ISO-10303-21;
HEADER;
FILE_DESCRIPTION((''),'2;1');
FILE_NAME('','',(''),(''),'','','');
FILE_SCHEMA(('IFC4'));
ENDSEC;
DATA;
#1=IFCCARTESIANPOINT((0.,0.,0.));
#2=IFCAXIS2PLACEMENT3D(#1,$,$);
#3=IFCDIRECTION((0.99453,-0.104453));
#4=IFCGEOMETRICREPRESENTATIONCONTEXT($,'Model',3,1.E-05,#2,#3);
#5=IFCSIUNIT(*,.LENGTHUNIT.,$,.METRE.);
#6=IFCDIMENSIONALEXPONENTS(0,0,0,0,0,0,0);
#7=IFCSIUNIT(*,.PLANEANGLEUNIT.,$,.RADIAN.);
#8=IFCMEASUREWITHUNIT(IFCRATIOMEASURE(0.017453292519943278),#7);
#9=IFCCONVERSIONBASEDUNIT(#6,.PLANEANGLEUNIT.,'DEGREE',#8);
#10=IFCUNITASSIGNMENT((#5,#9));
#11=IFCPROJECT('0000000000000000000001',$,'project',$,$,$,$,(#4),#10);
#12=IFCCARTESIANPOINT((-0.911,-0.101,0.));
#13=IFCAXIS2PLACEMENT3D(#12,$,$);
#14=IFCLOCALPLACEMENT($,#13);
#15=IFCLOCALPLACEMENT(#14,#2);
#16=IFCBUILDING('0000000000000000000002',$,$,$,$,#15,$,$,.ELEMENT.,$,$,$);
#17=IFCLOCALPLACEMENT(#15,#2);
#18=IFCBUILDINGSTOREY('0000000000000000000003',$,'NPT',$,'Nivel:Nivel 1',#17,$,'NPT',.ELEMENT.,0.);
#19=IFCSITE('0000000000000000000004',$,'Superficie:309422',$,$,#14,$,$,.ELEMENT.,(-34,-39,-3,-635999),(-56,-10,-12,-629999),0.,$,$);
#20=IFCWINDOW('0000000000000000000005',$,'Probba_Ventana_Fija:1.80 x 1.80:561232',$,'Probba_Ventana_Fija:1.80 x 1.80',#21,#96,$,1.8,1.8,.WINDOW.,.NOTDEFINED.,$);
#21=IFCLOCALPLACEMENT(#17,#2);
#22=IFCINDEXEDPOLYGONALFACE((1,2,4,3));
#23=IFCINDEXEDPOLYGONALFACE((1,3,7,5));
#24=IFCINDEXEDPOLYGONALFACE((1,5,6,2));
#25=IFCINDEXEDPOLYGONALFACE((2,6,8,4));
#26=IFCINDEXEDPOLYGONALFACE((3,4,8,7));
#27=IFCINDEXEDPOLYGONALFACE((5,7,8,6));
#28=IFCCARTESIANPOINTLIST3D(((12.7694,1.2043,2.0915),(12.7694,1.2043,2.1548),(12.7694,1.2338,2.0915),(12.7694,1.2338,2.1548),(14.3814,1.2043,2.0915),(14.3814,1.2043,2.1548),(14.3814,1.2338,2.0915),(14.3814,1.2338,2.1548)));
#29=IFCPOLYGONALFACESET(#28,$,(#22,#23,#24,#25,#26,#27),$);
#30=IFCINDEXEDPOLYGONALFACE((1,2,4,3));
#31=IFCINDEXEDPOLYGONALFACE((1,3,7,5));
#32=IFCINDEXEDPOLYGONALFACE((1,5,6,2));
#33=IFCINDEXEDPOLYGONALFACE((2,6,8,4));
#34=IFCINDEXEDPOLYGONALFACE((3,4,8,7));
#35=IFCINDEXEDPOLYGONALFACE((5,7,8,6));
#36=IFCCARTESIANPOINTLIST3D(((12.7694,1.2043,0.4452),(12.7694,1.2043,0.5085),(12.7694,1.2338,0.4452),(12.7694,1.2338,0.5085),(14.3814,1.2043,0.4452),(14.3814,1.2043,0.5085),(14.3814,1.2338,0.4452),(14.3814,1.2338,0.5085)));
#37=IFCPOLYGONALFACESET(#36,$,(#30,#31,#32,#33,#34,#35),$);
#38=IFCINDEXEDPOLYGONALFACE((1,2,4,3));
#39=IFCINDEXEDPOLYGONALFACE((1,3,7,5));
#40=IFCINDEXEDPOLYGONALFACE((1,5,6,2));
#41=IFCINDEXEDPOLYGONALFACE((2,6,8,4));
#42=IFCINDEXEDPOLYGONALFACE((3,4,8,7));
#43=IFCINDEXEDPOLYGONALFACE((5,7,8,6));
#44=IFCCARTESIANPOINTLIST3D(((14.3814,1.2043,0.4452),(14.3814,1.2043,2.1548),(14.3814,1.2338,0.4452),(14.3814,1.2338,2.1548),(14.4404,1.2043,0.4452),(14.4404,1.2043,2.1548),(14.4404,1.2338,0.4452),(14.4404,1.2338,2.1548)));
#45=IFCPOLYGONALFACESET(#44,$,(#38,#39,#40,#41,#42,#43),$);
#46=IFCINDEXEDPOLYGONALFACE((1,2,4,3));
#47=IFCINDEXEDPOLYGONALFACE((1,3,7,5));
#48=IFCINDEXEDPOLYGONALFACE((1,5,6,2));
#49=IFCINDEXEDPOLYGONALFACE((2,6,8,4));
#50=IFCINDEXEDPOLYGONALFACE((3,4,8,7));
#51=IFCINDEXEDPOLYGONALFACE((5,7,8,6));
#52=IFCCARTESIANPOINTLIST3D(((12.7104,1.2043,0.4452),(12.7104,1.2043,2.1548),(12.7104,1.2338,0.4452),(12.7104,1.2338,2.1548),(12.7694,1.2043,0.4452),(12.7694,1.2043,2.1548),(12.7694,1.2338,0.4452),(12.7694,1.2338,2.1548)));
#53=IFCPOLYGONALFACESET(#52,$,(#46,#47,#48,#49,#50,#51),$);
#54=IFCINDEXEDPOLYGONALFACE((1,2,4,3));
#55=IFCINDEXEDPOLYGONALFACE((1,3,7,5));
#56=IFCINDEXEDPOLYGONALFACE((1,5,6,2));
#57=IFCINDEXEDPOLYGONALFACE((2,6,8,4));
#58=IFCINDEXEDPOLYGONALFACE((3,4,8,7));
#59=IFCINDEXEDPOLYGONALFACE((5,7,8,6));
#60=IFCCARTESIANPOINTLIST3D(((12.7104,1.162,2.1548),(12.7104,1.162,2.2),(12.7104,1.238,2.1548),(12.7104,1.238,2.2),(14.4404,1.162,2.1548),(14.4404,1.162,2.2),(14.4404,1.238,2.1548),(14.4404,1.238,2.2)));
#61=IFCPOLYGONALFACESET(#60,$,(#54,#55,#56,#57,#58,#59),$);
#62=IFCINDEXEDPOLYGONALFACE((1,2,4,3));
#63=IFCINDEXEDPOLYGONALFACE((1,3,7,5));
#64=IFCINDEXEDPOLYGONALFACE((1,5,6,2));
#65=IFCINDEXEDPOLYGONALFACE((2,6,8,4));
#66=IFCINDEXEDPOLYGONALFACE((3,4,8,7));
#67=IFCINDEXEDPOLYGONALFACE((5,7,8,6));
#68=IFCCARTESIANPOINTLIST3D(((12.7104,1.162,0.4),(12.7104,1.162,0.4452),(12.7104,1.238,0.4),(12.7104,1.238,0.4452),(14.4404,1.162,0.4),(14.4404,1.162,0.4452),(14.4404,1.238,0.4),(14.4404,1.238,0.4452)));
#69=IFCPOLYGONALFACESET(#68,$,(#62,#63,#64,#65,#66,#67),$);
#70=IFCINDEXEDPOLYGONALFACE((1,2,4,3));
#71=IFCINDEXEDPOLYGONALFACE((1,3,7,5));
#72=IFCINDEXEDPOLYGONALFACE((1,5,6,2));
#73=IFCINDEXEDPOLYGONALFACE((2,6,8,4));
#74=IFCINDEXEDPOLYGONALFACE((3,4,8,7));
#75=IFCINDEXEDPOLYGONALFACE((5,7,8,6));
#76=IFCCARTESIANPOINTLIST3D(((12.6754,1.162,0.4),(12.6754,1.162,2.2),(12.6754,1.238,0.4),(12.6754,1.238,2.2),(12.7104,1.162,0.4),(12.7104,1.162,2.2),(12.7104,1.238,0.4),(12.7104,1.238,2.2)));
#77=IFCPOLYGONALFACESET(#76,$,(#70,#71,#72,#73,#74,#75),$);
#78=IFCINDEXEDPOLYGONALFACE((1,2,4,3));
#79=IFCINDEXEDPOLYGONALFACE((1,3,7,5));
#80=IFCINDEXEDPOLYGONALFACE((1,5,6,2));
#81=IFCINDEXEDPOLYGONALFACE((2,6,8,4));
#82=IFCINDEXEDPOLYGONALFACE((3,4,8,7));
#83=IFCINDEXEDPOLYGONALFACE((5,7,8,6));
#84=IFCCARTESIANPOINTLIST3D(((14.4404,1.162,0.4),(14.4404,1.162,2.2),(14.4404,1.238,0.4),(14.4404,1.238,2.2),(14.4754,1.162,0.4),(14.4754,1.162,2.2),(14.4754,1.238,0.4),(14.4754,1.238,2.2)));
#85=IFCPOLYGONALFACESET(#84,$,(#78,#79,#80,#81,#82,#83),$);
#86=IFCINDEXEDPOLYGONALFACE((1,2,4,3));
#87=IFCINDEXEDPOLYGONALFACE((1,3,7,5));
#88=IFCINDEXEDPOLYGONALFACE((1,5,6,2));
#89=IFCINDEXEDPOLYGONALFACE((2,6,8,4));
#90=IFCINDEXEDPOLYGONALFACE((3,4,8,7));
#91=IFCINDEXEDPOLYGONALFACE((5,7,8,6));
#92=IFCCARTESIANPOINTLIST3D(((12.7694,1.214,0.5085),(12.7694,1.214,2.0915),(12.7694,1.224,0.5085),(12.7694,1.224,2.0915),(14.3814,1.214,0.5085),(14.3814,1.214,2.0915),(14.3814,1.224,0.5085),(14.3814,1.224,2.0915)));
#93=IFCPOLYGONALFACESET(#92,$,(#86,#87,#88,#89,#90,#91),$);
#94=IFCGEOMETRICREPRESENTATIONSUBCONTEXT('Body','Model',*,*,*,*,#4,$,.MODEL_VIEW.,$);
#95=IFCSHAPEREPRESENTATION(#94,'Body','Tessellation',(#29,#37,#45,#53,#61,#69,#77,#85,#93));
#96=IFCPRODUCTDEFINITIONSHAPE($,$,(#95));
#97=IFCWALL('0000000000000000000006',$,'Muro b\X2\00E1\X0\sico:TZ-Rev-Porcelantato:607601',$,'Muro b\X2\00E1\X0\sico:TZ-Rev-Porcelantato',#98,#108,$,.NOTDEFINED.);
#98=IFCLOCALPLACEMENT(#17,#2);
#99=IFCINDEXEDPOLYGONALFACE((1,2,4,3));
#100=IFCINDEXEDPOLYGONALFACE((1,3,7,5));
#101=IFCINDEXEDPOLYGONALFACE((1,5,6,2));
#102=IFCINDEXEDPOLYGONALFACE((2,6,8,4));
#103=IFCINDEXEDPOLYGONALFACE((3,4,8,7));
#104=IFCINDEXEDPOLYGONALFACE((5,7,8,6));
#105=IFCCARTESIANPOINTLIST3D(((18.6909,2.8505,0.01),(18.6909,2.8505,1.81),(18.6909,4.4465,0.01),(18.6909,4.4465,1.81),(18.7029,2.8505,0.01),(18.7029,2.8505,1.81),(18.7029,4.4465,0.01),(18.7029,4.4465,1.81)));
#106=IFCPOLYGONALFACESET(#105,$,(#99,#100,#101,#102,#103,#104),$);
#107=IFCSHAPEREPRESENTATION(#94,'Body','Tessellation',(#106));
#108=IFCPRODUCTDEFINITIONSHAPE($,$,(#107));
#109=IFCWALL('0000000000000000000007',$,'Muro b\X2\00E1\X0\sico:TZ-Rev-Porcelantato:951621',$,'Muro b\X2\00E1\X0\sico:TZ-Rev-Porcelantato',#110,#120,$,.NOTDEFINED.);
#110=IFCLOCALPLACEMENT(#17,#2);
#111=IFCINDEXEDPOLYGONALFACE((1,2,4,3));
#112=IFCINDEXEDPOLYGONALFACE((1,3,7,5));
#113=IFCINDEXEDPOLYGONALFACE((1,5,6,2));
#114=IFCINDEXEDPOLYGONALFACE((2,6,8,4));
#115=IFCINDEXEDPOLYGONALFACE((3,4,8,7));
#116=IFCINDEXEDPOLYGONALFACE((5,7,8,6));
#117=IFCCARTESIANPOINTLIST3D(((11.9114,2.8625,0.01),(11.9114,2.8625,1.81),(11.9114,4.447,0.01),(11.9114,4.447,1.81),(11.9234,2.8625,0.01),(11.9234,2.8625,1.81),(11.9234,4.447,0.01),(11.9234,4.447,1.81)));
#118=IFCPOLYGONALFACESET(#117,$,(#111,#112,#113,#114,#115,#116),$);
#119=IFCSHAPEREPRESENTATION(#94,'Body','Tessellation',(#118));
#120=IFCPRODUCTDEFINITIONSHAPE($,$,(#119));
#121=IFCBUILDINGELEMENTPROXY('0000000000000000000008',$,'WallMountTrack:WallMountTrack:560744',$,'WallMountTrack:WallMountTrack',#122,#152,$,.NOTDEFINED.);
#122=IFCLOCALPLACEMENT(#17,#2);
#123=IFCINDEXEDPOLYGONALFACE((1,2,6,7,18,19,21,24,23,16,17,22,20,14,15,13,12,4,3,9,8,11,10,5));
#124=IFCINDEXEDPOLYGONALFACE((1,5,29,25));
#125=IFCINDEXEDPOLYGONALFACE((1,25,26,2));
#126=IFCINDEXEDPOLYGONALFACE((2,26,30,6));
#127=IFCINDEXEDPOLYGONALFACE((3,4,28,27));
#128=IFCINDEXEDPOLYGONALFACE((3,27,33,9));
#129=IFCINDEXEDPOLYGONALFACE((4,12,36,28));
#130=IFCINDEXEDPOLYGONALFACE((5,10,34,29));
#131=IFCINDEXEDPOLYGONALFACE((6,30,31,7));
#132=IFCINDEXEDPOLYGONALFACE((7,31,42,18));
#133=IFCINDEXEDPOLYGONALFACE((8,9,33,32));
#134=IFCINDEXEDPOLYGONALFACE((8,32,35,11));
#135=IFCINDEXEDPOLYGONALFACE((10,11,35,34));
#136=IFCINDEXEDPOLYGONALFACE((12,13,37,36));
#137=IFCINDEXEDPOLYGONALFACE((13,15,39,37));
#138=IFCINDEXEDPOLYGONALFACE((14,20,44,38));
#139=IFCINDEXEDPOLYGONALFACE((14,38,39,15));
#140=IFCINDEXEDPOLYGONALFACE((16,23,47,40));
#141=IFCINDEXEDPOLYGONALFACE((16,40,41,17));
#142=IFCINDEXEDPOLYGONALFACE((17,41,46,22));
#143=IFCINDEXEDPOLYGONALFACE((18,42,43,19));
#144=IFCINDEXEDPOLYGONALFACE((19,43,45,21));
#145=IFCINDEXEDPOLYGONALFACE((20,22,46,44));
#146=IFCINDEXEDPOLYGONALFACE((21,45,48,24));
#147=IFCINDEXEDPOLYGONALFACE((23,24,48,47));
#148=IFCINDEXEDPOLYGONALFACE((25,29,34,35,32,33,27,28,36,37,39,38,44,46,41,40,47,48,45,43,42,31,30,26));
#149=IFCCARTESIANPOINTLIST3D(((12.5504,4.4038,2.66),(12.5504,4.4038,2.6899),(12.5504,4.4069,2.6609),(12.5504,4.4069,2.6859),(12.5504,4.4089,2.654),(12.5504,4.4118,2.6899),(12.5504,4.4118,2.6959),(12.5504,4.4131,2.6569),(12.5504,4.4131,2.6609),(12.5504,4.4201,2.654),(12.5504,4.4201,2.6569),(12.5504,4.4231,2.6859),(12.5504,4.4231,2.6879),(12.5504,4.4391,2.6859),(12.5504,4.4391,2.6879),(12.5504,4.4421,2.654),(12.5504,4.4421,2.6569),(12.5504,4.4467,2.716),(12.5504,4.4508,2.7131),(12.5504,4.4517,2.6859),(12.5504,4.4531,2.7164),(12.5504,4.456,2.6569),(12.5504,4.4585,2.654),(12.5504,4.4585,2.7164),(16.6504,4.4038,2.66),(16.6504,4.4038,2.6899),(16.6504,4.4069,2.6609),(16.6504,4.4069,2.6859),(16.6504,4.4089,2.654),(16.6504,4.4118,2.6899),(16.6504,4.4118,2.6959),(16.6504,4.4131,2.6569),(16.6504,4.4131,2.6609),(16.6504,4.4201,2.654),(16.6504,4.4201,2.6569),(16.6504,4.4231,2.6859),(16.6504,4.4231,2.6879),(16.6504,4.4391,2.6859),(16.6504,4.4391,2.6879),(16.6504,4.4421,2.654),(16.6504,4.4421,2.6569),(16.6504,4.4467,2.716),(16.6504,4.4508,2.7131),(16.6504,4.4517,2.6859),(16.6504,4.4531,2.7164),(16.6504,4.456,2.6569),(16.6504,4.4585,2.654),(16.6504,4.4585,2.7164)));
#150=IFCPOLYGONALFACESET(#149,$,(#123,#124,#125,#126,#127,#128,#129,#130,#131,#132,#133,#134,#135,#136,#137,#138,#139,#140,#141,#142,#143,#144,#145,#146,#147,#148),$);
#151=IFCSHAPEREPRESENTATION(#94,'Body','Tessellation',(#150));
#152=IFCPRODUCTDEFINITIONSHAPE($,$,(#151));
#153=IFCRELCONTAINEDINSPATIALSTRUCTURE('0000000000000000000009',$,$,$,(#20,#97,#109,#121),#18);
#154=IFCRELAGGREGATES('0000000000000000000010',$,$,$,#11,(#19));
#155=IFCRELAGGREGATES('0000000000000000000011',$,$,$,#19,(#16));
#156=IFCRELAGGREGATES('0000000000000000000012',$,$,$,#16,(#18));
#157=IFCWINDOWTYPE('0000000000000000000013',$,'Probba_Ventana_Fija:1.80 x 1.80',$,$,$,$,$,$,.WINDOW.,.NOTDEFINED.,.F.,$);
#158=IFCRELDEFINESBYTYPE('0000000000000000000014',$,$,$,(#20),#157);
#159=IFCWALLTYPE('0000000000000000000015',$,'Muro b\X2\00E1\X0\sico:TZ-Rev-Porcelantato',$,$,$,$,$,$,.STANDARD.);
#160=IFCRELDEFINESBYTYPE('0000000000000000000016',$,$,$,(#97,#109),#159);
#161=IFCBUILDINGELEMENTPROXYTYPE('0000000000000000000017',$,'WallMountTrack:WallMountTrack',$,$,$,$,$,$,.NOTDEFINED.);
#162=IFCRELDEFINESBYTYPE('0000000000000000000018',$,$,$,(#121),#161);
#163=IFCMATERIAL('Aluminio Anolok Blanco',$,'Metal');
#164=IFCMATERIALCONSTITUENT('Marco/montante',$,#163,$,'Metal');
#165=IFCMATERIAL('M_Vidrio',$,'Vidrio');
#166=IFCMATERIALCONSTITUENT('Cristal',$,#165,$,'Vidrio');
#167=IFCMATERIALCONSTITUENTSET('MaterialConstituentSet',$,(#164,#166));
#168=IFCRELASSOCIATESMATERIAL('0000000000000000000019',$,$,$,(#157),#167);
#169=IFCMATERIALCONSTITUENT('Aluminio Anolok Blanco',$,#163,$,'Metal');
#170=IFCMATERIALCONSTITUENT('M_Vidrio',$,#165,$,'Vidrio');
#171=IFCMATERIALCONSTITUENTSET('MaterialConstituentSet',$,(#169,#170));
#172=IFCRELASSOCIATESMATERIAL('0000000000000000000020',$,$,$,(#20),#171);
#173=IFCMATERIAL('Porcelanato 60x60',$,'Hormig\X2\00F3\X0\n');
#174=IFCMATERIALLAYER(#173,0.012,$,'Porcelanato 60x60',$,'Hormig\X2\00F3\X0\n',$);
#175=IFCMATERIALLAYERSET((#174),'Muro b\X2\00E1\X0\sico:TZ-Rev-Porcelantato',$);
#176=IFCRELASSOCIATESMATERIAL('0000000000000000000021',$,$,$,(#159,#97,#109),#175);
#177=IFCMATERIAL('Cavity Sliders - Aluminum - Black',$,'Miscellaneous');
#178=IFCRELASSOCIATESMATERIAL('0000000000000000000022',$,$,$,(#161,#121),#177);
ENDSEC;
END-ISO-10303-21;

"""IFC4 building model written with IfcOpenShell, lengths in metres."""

from ifc_helpers import new_model, entity, si_unit, converted_unit, direction, frame, frame_2d, origin, origin_2d_with_axis, place, context, subcontext, project, spatial, polyline, rectangle, outline, extrude, source, transform, mapped, material, layer, layer_set, layer_usage, constituent, constituent_set, type_object, type_shapes, element, save


model = new_model("IFC4")

# Units and contexts
model_context = context("Model", 3, precision=1e-05, world=origin(), true_north=direction((0.99453, -0.104453)))
body_context = subcontext(model_context, "Body", "Model", "MODEL_VIEW")
ifc_project = project(units=[si_unit("LENGTHUNIT", "METRE"), converted_unit("PLANEANGLEUNIT", "DEGREE", entity("IfcRatioMeasure", 0.017453292519943278), si_unit("PLANEANGLEUNIT", "RADIAN"), dimensions=[0, 0, 0, 0, 0, 0, 0])], contexts=[model_context])

# Site, building, storey
site_placement = place(None, frame((-0.911, -0.101, 0.0)))
site = spatial("IfcSite", under=ifc_project, at=site_placement, Name="Superficie:309422", CompositionType="ELEMENT", RefLatitude=(-34, -39, -3, -635999), RefLongitude=(-56, -10, -12, -629999), RefElevation=0.0)
building_placement = place(site_placement, origin())
building = spatial("IfcBuilding", under=site, at=building_placement, CompositionType="ELEMENT")
storey_placement = place(building_placement, origin())
storey = spatial("IfcBuildingStorey", under=building, at=storey_placement, Name="NPT", ObjectType="Nivel:Nivel 1", LongName="NPT", CompositionType="ELEMENT", Elevation=0.0)

# Window
ifc_material_1 = material(Name="Aluminio Anolok Blanco", Category="Metal")
ifc_constituent_1 = constituent(ifc_material_1, Name="Aluminio Anolok Blanco", Category="Metal")
ifc_material_2 = material(Name="M_Vidrio", Category="Vidrio")
ifc_constituent_2 = constituent(ifc_material_2, Name="M_Vidrio", Category="Vidrio")
ifc_constituent_set_1 = constituent_set(constituents=[ifc_constituent_1, ifc_constituent_2], Name="MaterialConstituentSet")
ifc_constituent_3 = constituent(ifc_material_1, Name="Marco/montante", Category="Metal")
ifc_constituent_4 = constituent(ifc_material_2, Name="Cristal", Category="Vidrio")
ifc_constituent_set_2 = constituent_set(constituents=[ifc_constituent_3, ifc_constituent_4], Name="MaterialConstituentSet")
window_type = type_object("IfcWindowType", Name="Probba_Ventana_Fija:1.80 x 1.80", ParameterTakesPrecedence=False, PartitioningType="NOTDEFINED", PredefinedType="WINDOW", material=ifc_constituent_set_2)
shared_shape_1 = source(origin(), body_context, "Body", "SweptSolid", [
    extrude(rectangle(XDim=0.0295, YDim=1.612, at=origin_2d_with_axis()), frame((0.9, 0.019, 1.6915), z_axis=(0.0, 0.0, 1.0), x_axis=(0.0, 1.0, 0.0)), (0.0, 0.0, 1.0), 0.0633),
    extrude(rectangle(XDim=0.0295, YDim=1.612, at=frame_2d((0.0, 0.0), x_axis=(1.0, 0.0))), frame((0.9, 0.019, 0.0452), z_axis=(0.0, 0.0, 1.0), x_axis=(0.0, 1.0, 0.0)), (0.0, 0.0, 1.0), 0.0633),
    extrude(rectangle(XDim=0.059, YDim=0.0295, at=origin_2d_with_axis()), frame((0.0645, 0.019, 0.0452)), (0.0, 0.0, 1.0), 1.7096),
    extrude(rectangle(XDim=0.059, YDim=0.0295, at=origin_2d_with_axis()), frame((1.7355, 0.019, 0.0452)), (0.0, 0.0, 1.0), 1.7096),
    extrude(rectangle(XDim=0.076, YDim=1.73, at=frame_2d((0.0, 0.0), x_axis=(1.0, 0.0))), frame((0.9, 0.038, 1.7548), z_axis=(0.0, 0.0, 1.0), x_axis=(0.0, 1.0, 0.0)), (0.0, 0.0, 1.0), 0.0452),
    extrude(rectangle(XDim=0.076, YDim=1.73, at=frame_2d((0.0, 0.0), x_axis=(1.0, 0.0))), frame((0.9, 0.038, 0.0), z_axis=(0.0, 0.0, 1.0), x_axis=(0.0, 1.0, 0.0)), (0.0, 0.0, 1.0), 0.0452),
    extrude(rectangle(XDim=0.076, YDim=0.035, at=origin_2d_with_axis()), frame((1.7825, 0.038, 0.0), z_axis=(0.0, 0.0, 1.0), x_axis=(0.0, -1.0, 0.0)), (0.0, 0.0, 1.0), 1.8),
    extrude(rectangle(XDim=0.076, YDim=0.035, at=origin_2d_with_axis()), frame((0.0175, 0.038, 0.0), z_axis=(0.0, 0.0, 1.0), x_axis=(0.0, -1.0, 0.0)), (0.0, 0.0, 1.0), 1.8),
    extrude(rectangle(XDim=1.612, YDim=0.01, at=frame_2d((0.0, 0.0), x_axis=(1.0, 0.0))), frame((0.9, 0.019, 0.1085)), (0.0, 0.0, 1.0), 1.583),
])
type_shapes(window_type, [shared_shape_1])
window_placement = place(storey_placement, frame((14.4754, 1.238, 0.4), z_axis=(0.0, 0.0, 1.0), x_axis=(-1.0, 0.0, 0.0)))
element("IfcWindow", 1, at=window_placement, inside=storey, type_object=window_type, material=ifc_constituent_set_1, Name="Probba_Ventana_Fija:1.80 x 1.80:561232", ObjectType="Probba_Ventana_Fija:1.80 x 1.80", OverallHeight=1.8, OverallWidth=1.8, PartitioningType="NOTDEFINED", PredefinedType="WINDOW", context=body_context, shape_type="MappedRepresentation", body=[
    mapped(shared_shape_1, transform((0.0, 0.0, 0.0), scale=1.0)),
])

# Shared definitions
ifc_material_3 = material(Name="Porcelanato 60x60", Category="Hormigón")
ifc_layer_1 = layer(ifc_material_3, 0.012, Name="Porcelanato 60x60", Category="Hormigón")
ifc_layer_set_1 = layer_set([ifc_layer_1], Name="Muro básico:TZ-Rev-Porcelantato")
wall_type_1 = type_object("IfcWallType", Name="Muro básico:TZ-Rev-Porcelantato", PredefinedType="STANDARD", material=ifc_layer_set_1)

# Walls
ifc_layer_usage_1 = layer_usage(ifc_layer_set_1, "AXIS2", "NEGATIVE", 0.006)
wall_1_placement = place(storey_placement, frame((18.6969, 2.8505, 0.01), z_axis=(0.0, 0.0, 1.0), x_axis=(0.0, 1.0, 0.0)))
element("IfcWall", 2, at=wall_1_placement, inside=storey, type_object=wall_type_1, material=ifc_layer_usage_1, Name="Muro básico:TZ-Rev-Porcelantato:607601", ObjectType="Muro básico:TZ-Rev-Porcelantato", PredefinedType="NOTDEFINED", context=body_context, shape_type="SweptSolid", body=[
    extrude(rectangle(XDim=1.596, YDim=0.012, at=frame_2d((0.798, 0.0), x_axis=(-1.0, 0.0))), origin(), (0.0, 0.0, 1.0), 1.8),
])
ifc_layer_usage_2 = layer_usage(ifc_layer_set_1, "AXIS2", "POSITIVE", -0.006)
wall_2_placement = place(storey_placement, frame((11.9174, 2.8625, 0.01), z_axis=(0.0, 0.0, 1.0), x_axis=(0.0, 1.0, 0.0)))
element("IfcWall", 3, at=wall_2_placement, inside=storey, type_object=wall_type_1, material=ifc_layer_usage_2, Name="Muro básico:TZ-Rev-Porcelantato:951621", ObjectType="Muro básico:TZ-Rev-Porcelantato", PredefinedType="NOTDEFINED", context=body_context, shape_type="SweptSolid", body=[
    extrude(rectangle(XDim=1.5845, YDim=0.012, at=frame_2d((0.7922, 0.0), x_axis=(-1.0, 0.0))), origin(), (0.0, 0.0, 1.0), 1.8),
])

# Building element proxy
ifc_material_4 = material(Name="Cavity Sliders - Aluminum - Black", Category="Miscellaneous")
building_element_proxy_type_1 = type_object("IfcBuildingElementProxyType", Name="WallMountTrack:WallMountTrack", PredefinedType="NOTDEFINED", material=ifc_material_4)
shared_shape_2 = source(origin(), body_context, "Body", "SweptSolid", [
    extrude(outline(polyline([(-0.0255, 0.0115), (-0.0255, -0.0184), (-0.0205, -0.0244), (-0.0093, -0.0244), (-0.0093, -0.0215), (-0.0162, -0.0215), (-0.0162, -0.0175), (-0.0224, -0.0175), (-0.0224, 0.0075), (-0.0063, 0.0075), (-0.0063, 0.0095), (0.0097, 0.0095), (0.0097, 0.0075), (0.0223, 0.0075), (0.0267, -0.0215), (0.0127, -0.0215), (0.0127, -0.0244), (0.0291, -0.0244), (0.0291, 0.038), (0.0237, 0.038), (0.0215, 0.0347), (0.0174, 0.0376), (-0.0175, 0.0175), (-0.0175, 0.0115), (-0.0255, 0.0115)])), frame((-2.05, 0.0291, 0.0244), z_axis=(-1.0, 0.0, 0.0), x_axis=(0.0, -1.0, 0.0)), (0.0, 0.0, -1.0), 4.1),
])
type_shapes(building_element_proxy_type_1, [shared_shape_2])
proxy_1_placement = place(storey_placement, frame((14.6004, 4.4585, 2.654), z_axis=(0.0, 0.0, 1.0), x_axis=(-1.0, 0.0, 0.0)))
element("IfcBuildingElementProxy", 4, at=proxy_1_placement, inside=storey, type_object=building_element_proxy_type_1, material=ifc_material_4, Name="WallMountTrack:WallMountTrack:560744", ObjectType="WallMountTrack:WallMountTrack", PredefinedType="NOTDEFINED", context=body_context, shape_type="MappedRepresentation", body=[
    mapped(shared_shape_2, transform((0.0, 0.0, 0.0), scale=1.0)),
])

save(model, "model.ifc")
